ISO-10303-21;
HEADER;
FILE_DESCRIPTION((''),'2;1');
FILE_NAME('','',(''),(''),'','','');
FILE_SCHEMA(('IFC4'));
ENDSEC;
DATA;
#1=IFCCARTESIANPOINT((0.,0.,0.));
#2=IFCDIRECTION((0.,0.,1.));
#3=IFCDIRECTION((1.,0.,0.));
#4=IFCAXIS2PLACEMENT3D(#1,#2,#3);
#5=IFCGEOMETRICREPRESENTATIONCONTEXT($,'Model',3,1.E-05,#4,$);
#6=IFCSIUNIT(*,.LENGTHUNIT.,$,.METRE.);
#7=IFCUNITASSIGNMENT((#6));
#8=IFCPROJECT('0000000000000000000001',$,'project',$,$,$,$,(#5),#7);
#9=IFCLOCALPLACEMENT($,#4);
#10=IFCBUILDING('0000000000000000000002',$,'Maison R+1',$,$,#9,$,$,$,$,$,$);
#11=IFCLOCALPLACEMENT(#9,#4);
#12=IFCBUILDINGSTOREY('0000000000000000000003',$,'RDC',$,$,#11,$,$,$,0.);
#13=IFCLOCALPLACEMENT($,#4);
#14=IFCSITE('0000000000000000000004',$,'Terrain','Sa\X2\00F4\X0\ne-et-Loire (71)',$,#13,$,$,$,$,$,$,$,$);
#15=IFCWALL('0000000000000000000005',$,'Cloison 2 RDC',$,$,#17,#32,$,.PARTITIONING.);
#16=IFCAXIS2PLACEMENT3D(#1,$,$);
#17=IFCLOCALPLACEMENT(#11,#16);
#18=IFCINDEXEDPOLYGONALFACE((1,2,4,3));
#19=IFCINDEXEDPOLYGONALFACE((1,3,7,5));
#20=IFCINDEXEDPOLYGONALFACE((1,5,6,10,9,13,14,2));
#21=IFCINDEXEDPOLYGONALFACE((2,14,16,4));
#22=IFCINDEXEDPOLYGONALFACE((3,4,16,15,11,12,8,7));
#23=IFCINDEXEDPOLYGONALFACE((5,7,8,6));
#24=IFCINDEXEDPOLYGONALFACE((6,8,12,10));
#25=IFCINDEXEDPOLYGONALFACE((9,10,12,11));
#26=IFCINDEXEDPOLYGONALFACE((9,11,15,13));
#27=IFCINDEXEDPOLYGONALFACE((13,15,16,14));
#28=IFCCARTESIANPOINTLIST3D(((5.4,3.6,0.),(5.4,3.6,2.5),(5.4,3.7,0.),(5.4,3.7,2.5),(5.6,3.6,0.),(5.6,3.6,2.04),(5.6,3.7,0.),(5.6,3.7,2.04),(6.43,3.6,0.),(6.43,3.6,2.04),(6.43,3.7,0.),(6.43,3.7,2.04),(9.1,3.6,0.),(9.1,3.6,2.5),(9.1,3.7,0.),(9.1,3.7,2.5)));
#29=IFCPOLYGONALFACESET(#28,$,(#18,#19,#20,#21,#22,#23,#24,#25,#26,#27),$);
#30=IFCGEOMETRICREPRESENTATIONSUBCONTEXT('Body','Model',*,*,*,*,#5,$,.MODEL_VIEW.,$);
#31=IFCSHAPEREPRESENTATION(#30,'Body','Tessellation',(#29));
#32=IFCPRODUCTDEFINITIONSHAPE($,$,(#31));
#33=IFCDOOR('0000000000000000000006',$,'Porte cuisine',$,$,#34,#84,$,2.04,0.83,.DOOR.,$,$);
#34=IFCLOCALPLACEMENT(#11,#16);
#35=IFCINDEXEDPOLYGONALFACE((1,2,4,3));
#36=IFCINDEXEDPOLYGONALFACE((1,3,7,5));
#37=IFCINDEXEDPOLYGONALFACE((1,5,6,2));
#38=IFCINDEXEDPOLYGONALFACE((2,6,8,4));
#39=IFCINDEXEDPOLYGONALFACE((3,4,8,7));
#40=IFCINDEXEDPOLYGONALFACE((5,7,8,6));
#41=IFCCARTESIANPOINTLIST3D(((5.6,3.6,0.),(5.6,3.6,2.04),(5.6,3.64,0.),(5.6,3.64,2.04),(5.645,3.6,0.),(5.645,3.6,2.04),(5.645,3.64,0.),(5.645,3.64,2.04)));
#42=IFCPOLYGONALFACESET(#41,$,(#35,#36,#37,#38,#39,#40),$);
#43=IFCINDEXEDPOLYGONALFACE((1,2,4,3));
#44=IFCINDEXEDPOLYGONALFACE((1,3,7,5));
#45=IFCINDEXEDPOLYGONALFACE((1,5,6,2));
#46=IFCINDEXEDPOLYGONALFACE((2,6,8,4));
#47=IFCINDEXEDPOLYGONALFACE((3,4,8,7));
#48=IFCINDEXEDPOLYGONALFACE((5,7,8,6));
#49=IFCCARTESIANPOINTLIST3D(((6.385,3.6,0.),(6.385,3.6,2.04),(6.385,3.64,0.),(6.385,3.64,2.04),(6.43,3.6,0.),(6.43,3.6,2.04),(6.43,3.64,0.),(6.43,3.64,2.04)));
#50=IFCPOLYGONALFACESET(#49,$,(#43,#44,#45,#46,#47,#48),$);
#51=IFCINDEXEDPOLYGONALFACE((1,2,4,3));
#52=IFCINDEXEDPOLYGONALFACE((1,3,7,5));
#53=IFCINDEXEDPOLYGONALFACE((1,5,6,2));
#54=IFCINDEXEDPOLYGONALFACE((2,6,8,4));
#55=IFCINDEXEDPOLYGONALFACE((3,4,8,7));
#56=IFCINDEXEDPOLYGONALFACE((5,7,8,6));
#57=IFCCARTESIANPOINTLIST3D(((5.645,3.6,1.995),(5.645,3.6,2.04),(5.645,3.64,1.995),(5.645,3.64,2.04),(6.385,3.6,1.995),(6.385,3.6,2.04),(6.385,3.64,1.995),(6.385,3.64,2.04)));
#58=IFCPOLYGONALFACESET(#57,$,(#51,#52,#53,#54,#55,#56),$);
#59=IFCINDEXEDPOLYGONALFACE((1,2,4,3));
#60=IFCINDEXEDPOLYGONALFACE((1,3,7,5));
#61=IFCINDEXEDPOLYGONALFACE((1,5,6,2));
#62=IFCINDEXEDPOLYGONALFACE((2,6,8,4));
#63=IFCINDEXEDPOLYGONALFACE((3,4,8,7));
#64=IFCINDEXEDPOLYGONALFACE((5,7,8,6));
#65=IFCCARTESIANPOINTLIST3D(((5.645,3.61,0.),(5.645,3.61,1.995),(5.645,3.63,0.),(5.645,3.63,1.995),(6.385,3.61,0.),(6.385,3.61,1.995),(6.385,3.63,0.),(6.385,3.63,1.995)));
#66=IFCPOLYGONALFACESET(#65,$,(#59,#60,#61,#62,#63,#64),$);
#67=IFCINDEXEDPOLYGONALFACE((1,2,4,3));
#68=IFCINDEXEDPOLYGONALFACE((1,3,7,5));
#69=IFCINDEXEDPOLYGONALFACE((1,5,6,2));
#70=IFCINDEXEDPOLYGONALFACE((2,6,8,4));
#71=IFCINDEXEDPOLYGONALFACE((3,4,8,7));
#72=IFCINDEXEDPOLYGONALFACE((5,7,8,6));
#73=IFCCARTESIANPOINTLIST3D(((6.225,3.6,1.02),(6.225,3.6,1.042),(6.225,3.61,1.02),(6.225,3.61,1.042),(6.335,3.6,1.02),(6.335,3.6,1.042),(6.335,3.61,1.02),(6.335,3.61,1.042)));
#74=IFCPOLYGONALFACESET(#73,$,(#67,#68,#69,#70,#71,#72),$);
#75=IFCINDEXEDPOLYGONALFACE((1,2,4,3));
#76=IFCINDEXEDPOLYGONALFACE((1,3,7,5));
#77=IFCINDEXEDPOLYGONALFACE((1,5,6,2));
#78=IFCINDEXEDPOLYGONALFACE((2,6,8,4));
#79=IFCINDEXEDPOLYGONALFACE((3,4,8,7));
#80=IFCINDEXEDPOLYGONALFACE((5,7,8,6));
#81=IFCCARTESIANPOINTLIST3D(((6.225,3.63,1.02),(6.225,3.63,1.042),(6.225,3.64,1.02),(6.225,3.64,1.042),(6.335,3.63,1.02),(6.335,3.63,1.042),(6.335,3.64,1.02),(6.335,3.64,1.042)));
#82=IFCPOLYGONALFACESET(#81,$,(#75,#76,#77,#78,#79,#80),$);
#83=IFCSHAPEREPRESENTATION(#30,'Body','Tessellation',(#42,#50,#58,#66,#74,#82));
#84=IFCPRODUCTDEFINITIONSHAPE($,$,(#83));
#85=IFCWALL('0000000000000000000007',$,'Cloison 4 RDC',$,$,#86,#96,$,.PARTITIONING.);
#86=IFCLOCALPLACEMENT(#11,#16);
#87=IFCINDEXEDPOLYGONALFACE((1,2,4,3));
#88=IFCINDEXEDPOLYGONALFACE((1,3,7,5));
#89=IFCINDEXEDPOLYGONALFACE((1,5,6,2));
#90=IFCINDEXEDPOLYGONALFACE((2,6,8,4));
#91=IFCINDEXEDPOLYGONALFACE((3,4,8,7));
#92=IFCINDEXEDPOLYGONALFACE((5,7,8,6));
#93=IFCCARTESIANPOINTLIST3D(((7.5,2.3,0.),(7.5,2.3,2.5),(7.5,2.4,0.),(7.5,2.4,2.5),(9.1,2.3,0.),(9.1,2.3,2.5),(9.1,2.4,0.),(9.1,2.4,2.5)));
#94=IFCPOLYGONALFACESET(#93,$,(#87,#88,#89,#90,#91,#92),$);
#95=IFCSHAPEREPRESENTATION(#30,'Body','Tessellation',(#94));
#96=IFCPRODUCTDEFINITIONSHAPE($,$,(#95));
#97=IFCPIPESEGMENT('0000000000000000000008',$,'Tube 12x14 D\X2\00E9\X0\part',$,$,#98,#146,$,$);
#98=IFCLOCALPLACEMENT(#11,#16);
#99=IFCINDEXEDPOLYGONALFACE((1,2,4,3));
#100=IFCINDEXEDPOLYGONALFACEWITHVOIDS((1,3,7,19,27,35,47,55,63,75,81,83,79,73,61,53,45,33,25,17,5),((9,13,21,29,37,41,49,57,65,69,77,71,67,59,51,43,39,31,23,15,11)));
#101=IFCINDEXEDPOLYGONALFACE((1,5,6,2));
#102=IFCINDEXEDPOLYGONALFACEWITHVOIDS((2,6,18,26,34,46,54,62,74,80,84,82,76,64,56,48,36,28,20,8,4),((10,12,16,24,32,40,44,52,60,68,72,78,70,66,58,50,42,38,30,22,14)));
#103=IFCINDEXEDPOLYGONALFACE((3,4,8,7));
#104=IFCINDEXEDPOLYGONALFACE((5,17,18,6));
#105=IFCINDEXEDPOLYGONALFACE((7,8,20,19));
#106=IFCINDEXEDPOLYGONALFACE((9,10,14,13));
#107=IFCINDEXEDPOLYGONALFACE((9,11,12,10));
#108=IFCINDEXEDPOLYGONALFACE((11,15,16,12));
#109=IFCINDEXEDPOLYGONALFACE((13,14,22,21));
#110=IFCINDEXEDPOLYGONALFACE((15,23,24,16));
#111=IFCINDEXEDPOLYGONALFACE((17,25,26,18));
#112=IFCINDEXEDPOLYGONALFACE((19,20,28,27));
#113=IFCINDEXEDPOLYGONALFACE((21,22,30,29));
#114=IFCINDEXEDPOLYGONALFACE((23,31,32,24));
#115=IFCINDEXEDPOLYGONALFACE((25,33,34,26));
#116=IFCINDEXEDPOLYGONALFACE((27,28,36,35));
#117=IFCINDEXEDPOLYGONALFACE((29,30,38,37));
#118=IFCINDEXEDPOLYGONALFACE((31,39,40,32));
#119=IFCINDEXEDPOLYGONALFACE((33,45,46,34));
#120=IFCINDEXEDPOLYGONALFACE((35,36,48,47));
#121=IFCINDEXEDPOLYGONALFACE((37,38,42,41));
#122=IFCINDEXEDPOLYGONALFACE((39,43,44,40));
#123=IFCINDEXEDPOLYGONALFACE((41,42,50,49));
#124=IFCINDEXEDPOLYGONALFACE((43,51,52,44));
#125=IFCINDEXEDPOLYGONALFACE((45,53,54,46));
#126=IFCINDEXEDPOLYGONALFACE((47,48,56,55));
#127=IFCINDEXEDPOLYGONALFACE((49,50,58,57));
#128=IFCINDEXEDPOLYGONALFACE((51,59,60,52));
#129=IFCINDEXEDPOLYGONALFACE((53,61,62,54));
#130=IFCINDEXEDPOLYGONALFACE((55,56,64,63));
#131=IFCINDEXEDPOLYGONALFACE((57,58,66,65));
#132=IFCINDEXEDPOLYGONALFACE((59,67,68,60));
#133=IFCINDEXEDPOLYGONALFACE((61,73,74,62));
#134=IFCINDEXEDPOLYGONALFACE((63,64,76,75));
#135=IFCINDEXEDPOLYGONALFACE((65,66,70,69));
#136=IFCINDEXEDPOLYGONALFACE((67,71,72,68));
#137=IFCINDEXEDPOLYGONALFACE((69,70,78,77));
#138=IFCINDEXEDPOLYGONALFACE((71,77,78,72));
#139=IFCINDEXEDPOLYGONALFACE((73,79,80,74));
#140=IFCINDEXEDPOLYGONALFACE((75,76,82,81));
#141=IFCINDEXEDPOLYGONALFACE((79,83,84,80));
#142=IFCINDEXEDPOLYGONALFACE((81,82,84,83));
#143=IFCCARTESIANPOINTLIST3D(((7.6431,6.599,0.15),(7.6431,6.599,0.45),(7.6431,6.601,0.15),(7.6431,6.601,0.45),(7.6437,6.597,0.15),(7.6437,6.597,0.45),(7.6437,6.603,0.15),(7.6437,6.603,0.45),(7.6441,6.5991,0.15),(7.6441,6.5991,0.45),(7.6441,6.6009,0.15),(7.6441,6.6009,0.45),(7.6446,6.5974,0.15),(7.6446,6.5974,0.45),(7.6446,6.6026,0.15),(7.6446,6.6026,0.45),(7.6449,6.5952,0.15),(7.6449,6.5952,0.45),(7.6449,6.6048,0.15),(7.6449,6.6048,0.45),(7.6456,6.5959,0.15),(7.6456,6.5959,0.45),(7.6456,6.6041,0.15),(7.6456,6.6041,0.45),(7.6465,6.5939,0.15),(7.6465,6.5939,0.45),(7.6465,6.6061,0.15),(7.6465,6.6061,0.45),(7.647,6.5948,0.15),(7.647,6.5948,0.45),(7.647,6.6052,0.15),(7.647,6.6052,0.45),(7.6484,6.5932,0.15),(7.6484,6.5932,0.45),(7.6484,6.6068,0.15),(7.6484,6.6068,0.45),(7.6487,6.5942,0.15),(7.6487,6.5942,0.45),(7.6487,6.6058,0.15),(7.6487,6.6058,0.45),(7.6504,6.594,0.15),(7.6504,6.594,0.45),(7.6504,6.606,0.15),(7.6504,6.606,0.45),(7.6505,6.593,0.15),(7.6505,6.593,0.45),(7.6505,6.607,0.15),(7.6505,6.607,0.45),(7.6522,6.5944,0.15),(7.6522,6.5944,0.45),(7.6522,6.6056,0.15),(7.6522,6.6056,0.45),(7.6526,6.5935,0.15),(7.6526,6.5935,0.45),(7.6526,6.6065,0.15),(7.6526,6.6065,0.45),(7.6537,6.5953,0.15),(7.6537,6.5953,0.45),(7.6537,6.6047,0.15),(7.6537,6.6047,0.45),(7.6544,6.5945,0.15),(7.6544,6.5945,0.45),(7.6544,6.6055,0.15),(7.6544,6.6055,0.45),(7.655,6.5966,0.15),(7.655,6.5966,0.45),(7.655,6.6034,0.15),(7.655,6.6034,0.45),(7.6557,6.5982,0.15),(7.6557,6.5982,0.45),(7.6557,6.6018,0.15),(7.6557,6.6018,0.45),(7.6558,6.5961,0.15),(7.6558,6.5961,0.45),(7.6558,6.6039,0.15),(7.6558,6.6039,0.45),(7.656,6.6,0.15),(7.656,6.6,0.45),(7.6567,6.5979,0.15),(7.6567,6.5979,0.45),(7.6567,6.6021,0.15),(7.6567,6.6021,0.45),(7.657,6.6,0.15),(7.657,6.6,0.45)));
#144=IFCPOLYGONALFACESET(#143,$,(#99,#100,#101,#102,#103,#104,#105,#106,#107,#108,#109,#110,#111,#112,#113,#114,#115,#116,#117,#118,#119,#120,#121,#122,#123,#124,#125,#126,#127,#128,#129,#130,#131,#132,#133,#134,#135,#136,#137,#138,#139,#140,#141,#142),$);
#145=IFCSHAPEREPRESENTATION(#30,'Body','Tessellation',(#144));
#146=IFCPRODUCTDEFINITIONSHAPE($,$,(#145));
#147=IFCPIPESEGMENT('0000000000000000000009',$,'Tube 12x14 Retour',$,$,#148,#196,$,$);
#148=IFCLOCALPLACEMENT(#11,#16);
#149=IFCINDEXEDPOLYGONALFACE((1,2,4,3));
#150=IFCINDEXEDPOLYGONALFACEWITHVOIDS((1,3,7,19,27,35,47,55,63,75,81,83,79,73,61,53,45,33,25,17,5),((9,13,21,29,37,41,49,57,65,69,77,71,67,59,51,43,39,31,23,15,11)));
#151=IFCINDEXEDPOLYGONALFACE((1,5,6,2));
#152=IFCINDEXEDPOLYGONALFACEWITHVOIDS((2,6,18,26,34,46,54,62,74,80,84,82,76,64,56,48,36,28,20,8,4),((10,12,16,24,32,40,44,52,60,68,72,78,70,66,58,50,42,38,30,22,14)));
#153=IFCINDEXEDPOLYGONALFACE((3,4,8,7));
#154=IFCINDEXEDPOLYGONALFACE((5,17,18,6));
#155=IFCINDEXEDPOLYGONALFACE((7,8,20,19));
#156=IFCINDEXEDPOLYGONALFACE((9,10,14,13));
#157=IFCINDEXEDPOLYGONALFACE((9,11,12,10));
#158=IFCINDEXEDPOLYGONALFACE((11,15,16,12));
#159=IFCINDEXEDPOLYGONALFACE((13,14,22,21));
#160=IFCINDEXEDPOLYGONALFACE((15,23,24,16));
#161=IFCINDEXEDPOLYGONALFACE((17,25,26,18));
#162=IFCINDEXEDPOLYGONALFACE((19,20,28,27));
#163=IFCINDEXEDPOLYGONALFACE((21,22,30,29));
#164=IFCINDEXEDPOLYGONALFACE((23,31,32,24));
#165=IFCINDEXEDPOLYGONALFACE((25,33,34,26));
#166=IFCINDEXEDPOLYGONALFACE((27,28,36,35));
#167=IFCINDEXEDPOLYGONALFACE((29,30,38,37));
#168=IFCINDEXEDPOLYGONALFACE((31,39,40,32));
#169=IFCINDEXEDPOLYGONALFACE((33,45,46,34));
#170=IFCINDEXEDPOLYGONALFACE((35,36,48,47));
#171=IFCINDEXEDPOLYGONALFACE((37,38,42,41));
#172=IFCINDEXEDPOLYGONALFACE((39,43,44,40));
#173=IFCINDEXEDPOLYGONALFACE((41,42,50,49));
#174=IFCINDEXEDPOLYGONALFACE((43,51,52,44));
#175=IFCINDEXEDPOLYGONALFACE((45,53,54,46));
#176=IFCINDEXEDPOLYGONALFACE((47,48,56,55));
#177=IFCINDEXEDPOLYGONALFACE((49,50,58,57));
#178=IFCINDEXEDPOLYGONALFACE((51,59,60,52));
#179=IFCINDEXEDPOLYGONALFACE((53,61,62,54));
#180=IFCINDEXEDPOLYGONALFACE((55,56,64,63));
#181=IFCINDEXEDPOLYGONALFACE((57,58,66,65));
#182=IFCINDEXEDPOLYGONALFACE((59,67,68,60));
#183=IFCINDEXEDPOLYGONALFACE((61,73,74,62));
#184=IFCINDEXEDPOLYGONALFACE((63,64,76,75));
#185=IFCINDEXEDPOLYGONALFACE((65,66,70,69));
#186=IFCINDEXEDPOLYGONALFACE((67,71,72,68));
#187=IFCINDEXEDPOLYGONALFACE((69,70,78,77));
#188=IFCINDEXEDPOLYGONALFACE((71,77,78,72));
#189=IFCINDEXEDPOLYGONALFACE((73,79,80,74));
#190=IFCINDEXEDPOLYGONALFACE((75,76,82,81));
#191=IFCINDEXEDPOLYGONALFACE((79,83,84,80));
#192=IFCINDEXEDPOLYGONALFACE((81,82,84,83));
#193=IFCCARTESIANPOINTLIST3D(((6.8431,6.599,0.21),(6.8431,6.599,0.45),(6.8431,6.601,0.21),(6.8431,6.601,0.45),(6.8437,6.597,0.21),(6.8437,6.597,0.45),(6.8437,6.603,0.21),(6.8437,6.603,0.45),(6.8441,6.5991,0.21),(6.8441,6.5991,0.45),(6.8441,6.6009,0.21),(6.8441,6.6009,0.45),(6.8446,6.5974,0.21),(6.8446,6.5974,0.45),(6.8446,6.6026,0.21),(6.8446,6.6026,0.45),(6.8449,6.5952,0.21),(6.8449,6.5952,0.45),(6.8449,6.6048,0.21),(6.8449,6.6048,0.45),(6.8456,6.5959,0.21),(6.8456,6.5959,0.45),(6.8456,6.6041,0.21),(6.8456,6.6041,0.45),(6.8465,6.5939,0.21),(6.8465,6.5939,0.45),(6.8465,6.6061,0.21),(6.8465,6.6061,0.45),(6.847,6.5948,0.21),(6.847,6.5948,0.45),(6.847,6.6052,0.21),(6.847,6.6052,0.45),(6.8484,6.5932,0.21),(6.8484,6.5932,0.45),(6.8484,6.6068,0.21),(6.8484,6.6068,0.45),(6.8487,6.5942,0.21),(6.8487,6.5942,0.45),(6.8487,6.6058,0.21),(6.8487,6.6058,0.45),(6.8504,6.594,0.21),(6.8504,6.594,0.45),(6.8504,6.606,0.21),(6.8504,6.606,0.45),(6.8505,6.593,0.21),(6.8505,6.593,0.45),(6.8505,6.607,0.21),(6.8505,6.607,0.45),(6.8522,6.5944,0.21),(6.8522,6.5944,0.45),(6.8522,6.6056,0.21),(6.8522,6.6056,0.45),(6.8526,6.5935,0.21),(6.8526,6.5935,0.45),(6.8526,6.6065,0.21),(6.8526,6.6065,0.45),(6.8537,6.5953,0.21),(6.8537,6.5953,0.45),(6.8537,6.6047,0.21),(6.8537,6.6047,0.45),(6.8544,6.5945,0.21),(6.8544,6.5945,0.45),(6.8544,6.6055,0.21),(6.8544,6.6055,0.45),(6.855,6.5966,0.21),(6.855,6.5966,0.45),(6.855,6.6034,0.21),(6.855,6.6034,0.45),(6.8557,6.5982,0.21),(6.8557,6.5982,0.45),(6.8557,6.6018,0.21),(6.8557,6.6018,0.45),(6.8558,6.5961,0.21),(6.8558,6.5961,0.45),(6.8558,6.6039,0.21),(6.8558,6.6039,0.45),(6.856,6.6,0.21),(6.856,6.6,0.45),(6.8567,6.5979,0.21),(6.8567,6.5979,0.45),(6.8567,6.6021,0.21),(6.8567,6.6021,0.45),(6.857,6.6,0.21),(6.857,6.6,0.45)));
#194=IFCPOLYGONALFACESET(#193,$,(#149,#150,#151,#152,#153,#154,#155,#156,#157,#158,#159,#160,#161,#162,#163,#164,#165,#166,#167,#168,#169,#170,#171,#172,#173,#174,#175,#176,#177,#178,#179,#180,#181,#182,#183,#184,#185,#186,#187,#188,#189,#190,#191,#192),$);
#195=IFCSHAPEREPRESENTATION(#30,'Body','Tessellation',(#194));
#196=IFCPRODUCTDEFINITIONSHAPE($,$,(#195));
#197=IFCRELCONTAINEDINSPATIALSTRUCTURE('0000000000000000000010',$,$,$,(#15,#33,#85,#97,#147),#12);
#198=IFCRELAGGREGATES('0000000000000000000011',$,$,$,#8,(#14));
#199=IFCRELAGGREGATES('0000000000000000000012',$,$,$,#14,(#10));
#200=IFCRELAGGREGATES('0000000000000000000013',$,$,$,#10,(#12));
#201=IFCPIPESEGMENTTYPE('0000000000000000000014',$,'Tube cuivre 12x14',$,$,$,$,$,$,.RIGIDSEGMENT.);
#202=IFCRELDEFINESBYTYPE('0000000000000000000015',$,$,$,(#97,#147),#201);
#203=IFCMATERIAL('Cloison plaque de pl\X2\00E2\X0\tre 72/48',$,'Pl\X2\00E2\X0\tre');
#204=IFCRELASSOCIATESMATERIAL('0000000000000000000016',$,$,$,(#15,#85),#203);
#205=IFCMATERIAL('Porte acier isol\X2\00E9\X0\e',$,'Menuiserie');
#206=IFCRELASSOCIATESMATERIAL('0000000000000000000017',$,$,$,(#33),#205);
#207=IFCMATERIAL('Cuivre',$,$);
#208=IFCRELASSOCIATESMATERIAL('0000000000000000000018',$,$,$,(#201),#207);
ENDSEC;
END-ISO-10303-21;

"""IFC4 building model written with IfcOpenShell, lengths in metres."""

from ifc_helpers import new_model, si_unit, frame, frame_2d, origin_with_axes, place, context, subcontext, project, spatial, rectangle, hollow_circle, extrude, material, type_object, element, fill, save


model = new_model("IFC4")

# Units and contexts
model_context = context("Model", 3, precision=1e-05, world=origin_with_axes())
body_context = subcontext(model_context, "Body", "Model", "MODEL_VIEW")
ifc_project = project(units=[si_unit("LENGTHUNIT", "METRE")], contexts=[model_context])

# Site, building, storey
site_placement = place(None, origin_with_axes())
site = spatial("IfcSite", under=ifc_project, at=site_placement, Name="Terrain", Description="Saône-et-Loire (71)")
building_placement = place(None, origin_with_axes())
building = spatial("IfcBuilding", under=site, at=building_placement, Name="Maison R+1")
storey_placement = place(building_placement, origin_with_axes())
storey = spatial("IfcBuildingStorey", under=building, at=storey_placement, Name="RDC", Elevation=0.0)

# Wall, opening, door
ifc_material_1 = material(Name="Cloison plaque de plâtre 72/48", Category="Plâtre")
wall_1_placement = place(storey_placement, frame((5.4, 3.6, 0.0), z_axis=(0.0, 0.0, 1.0), x_axis=(1.0, 0.0, 0.0)))
wall_1 = element("IfcWall", 1, at=wall_1_placement, inside=storey, material=ifc_material_1, Name="Cloison 2 RDC", PredefinedType="PARTITIONING", context=body_context, shape_type="SweptSolid", body=[
    extrude(rectangle(XDim=3.7, YDim=0.1, at=frame_2d((1.85, 0.05))), origin_with_axes(), (0.0, 0.0, 1.0), 2.5),
])
opening_placement = place(storey_placement, frame((5.6, 3.55, 0.0), z_axis=(0.0, 0.0, 1.0), x_axis=(1.0, 0.0, 0.0)))
opening = element("IfcOpeningElement", 2, at=opening_placement, cuts=wall_1, context=body_context, shape_type="SweptSolid", body=[
    extrude(rectangle(XDim=0.83, YDim=0.2, at=frame_2d((0.415, 0.1))), origin_with_axes(), (0.0, 0.0, 1.0), 2.04),
])
ifc_material_2 = material(Name="Porte acier isolée", Category="Menuiserie")
door_placement = place(storey_placement, frame((5.6, 3.6, 0.0), z_axis=(0.0, 0.0, 1.0), x_axis=(1.0, 0.0, 0.0)))
door = element("IfcDoor", 3, at=door_placement, inside=storey, material=ifc_material_2, Name="Porte cuisine", OverallHeight=2.04, OverallWidth=0.83, PredefinedType="DOOR", context=body_context, shape_type="SweptSolid", body=[
    extrude(rectangle(XDim=0.045, YDim=0.04, at=frame_2d((0.0225, 0.02))), origin_with_axes(), (0.0, 0.0, 1.0), 2.04),
    extrude(rectangle(XDim=0.045, YDim=0.04, at=frame_2d((0.0225, 0.02))), frame((0.785, 0.0, 0.0), z_axis=(0.0, 0.0, 1.0), x_axis=(1.0, 0.0, 0.0)), (0.0, 0.0, 1.0), 2.04),
    extrude(rectangle(XDim=0.74, YDim=0.04, at=frame_2d((0.37, 0.02))), frame((0.045, 0.0, 1.995), z_axis=(0.0, 0.0, 1.0), x_axis=(1.0, 0.0, 0.0)), (0.0, 0.0, 1.0), 0.045),
    extrude(rectangle(XDim=0.74, YDim=0.02, at=frame_2d((0.37, 0.01))), frame((0.045, 0.01, 0.0), z_axis=(0.0, 0.0, 1.0), x_axis=(1.0, 0.0, 0.0)), (0.0, 0.0, 1.0), 1.995),
    extrude(rectangle(XDim=0.11, YDim=0.01, at=frame_2d((0.055, 0.005))), frame((0.625, 0.0, 1.02), z_axis=(0.0, 0.0, 1.0), x_axis=(1.0, 0.0, 0.0)), (0.0, 0.0, 1.0), 0.022),
    extrude(rectangle(XDim=0.11, YDim=0.01, at=frame_2d((0.055, 0.005))), frame((0.625, 0.03, 1.02), z_axis=(0.0, 0.0, 1.0), x_axis=(1.0, 0.0, 0.0)), (0.0, 0.0, 1.0), 0.022),
])
fill(opening, door)

# Wall
wall_2_placement = place(storey_placement, frame((7.5, 2.3, 0.0), z_axis=(0.0, 0.0, 1.0), x_axis=(1.0, 0.0, 0.0)))
element("IfcWall", 4, at=wall_2_placement, inside=storey, material=ifc_material_1, Name="Cloison 4 RDC", PredefinedType="PARTITIONING", context=body_context, shape_type="SweptSolid", body=[
    extrude(rectangle(XDim=1.6, YDim=0.1, at=frame_2d((0.8, 0.05))), origin_with_axes(), (0.0, 0.0, 1.0), 2.5),
])

# Pipe segments
ifc_material_3 = material(Name="Cuivre")
pipe_segment_type_1 = type_object("IfcPipeSegmentType", Name="Tube cuivre 12x14", PredefinedType="RIGIDSEGMENT", material=ifc_material_3)
pipe_segment_1_placement = place(storey_placement, frame((7.65, 6.6, 0.15), z_axis=(0.0, 0.0, 1.0), x_axis=(1.0, 0.0, 0.0)))
element("IfcPipeSegment", 5, at=pipe_segment_1_placement, inside=storey, type_object=pipe_segment_type_1, Name="Tube 12x14 Départ", context=body_context, shape_type="SweptSolid", body=[
    extrude(hollow_circle(Radius=0.007, WallThickness=0.001), origin_with_axes(), (0.0, 0.0, 1.0), 0.3),
])
pipe_segment_2_placement = place(storey_placement, frame((6.85, 6.6, 0.21), z_axis=(0.0, 0.0, 1.0), x_axis=(1.0, 0.0, 0.0)))
element("IfcPipeSegment", 6, at=pipe_segment_2_placement, inside=storey, type_object=pipe_segment_type_1, Name="Tube 12x14 Retour", context=body_context, shape_type="SweptSolid", body=[
    extrude(hollow_circle(Radius=0.007, WallThickness=0.001), origin_with_axes(), (0.0, 0.0, 1.0), 0.24),
])

save(model, "model.ifc")
